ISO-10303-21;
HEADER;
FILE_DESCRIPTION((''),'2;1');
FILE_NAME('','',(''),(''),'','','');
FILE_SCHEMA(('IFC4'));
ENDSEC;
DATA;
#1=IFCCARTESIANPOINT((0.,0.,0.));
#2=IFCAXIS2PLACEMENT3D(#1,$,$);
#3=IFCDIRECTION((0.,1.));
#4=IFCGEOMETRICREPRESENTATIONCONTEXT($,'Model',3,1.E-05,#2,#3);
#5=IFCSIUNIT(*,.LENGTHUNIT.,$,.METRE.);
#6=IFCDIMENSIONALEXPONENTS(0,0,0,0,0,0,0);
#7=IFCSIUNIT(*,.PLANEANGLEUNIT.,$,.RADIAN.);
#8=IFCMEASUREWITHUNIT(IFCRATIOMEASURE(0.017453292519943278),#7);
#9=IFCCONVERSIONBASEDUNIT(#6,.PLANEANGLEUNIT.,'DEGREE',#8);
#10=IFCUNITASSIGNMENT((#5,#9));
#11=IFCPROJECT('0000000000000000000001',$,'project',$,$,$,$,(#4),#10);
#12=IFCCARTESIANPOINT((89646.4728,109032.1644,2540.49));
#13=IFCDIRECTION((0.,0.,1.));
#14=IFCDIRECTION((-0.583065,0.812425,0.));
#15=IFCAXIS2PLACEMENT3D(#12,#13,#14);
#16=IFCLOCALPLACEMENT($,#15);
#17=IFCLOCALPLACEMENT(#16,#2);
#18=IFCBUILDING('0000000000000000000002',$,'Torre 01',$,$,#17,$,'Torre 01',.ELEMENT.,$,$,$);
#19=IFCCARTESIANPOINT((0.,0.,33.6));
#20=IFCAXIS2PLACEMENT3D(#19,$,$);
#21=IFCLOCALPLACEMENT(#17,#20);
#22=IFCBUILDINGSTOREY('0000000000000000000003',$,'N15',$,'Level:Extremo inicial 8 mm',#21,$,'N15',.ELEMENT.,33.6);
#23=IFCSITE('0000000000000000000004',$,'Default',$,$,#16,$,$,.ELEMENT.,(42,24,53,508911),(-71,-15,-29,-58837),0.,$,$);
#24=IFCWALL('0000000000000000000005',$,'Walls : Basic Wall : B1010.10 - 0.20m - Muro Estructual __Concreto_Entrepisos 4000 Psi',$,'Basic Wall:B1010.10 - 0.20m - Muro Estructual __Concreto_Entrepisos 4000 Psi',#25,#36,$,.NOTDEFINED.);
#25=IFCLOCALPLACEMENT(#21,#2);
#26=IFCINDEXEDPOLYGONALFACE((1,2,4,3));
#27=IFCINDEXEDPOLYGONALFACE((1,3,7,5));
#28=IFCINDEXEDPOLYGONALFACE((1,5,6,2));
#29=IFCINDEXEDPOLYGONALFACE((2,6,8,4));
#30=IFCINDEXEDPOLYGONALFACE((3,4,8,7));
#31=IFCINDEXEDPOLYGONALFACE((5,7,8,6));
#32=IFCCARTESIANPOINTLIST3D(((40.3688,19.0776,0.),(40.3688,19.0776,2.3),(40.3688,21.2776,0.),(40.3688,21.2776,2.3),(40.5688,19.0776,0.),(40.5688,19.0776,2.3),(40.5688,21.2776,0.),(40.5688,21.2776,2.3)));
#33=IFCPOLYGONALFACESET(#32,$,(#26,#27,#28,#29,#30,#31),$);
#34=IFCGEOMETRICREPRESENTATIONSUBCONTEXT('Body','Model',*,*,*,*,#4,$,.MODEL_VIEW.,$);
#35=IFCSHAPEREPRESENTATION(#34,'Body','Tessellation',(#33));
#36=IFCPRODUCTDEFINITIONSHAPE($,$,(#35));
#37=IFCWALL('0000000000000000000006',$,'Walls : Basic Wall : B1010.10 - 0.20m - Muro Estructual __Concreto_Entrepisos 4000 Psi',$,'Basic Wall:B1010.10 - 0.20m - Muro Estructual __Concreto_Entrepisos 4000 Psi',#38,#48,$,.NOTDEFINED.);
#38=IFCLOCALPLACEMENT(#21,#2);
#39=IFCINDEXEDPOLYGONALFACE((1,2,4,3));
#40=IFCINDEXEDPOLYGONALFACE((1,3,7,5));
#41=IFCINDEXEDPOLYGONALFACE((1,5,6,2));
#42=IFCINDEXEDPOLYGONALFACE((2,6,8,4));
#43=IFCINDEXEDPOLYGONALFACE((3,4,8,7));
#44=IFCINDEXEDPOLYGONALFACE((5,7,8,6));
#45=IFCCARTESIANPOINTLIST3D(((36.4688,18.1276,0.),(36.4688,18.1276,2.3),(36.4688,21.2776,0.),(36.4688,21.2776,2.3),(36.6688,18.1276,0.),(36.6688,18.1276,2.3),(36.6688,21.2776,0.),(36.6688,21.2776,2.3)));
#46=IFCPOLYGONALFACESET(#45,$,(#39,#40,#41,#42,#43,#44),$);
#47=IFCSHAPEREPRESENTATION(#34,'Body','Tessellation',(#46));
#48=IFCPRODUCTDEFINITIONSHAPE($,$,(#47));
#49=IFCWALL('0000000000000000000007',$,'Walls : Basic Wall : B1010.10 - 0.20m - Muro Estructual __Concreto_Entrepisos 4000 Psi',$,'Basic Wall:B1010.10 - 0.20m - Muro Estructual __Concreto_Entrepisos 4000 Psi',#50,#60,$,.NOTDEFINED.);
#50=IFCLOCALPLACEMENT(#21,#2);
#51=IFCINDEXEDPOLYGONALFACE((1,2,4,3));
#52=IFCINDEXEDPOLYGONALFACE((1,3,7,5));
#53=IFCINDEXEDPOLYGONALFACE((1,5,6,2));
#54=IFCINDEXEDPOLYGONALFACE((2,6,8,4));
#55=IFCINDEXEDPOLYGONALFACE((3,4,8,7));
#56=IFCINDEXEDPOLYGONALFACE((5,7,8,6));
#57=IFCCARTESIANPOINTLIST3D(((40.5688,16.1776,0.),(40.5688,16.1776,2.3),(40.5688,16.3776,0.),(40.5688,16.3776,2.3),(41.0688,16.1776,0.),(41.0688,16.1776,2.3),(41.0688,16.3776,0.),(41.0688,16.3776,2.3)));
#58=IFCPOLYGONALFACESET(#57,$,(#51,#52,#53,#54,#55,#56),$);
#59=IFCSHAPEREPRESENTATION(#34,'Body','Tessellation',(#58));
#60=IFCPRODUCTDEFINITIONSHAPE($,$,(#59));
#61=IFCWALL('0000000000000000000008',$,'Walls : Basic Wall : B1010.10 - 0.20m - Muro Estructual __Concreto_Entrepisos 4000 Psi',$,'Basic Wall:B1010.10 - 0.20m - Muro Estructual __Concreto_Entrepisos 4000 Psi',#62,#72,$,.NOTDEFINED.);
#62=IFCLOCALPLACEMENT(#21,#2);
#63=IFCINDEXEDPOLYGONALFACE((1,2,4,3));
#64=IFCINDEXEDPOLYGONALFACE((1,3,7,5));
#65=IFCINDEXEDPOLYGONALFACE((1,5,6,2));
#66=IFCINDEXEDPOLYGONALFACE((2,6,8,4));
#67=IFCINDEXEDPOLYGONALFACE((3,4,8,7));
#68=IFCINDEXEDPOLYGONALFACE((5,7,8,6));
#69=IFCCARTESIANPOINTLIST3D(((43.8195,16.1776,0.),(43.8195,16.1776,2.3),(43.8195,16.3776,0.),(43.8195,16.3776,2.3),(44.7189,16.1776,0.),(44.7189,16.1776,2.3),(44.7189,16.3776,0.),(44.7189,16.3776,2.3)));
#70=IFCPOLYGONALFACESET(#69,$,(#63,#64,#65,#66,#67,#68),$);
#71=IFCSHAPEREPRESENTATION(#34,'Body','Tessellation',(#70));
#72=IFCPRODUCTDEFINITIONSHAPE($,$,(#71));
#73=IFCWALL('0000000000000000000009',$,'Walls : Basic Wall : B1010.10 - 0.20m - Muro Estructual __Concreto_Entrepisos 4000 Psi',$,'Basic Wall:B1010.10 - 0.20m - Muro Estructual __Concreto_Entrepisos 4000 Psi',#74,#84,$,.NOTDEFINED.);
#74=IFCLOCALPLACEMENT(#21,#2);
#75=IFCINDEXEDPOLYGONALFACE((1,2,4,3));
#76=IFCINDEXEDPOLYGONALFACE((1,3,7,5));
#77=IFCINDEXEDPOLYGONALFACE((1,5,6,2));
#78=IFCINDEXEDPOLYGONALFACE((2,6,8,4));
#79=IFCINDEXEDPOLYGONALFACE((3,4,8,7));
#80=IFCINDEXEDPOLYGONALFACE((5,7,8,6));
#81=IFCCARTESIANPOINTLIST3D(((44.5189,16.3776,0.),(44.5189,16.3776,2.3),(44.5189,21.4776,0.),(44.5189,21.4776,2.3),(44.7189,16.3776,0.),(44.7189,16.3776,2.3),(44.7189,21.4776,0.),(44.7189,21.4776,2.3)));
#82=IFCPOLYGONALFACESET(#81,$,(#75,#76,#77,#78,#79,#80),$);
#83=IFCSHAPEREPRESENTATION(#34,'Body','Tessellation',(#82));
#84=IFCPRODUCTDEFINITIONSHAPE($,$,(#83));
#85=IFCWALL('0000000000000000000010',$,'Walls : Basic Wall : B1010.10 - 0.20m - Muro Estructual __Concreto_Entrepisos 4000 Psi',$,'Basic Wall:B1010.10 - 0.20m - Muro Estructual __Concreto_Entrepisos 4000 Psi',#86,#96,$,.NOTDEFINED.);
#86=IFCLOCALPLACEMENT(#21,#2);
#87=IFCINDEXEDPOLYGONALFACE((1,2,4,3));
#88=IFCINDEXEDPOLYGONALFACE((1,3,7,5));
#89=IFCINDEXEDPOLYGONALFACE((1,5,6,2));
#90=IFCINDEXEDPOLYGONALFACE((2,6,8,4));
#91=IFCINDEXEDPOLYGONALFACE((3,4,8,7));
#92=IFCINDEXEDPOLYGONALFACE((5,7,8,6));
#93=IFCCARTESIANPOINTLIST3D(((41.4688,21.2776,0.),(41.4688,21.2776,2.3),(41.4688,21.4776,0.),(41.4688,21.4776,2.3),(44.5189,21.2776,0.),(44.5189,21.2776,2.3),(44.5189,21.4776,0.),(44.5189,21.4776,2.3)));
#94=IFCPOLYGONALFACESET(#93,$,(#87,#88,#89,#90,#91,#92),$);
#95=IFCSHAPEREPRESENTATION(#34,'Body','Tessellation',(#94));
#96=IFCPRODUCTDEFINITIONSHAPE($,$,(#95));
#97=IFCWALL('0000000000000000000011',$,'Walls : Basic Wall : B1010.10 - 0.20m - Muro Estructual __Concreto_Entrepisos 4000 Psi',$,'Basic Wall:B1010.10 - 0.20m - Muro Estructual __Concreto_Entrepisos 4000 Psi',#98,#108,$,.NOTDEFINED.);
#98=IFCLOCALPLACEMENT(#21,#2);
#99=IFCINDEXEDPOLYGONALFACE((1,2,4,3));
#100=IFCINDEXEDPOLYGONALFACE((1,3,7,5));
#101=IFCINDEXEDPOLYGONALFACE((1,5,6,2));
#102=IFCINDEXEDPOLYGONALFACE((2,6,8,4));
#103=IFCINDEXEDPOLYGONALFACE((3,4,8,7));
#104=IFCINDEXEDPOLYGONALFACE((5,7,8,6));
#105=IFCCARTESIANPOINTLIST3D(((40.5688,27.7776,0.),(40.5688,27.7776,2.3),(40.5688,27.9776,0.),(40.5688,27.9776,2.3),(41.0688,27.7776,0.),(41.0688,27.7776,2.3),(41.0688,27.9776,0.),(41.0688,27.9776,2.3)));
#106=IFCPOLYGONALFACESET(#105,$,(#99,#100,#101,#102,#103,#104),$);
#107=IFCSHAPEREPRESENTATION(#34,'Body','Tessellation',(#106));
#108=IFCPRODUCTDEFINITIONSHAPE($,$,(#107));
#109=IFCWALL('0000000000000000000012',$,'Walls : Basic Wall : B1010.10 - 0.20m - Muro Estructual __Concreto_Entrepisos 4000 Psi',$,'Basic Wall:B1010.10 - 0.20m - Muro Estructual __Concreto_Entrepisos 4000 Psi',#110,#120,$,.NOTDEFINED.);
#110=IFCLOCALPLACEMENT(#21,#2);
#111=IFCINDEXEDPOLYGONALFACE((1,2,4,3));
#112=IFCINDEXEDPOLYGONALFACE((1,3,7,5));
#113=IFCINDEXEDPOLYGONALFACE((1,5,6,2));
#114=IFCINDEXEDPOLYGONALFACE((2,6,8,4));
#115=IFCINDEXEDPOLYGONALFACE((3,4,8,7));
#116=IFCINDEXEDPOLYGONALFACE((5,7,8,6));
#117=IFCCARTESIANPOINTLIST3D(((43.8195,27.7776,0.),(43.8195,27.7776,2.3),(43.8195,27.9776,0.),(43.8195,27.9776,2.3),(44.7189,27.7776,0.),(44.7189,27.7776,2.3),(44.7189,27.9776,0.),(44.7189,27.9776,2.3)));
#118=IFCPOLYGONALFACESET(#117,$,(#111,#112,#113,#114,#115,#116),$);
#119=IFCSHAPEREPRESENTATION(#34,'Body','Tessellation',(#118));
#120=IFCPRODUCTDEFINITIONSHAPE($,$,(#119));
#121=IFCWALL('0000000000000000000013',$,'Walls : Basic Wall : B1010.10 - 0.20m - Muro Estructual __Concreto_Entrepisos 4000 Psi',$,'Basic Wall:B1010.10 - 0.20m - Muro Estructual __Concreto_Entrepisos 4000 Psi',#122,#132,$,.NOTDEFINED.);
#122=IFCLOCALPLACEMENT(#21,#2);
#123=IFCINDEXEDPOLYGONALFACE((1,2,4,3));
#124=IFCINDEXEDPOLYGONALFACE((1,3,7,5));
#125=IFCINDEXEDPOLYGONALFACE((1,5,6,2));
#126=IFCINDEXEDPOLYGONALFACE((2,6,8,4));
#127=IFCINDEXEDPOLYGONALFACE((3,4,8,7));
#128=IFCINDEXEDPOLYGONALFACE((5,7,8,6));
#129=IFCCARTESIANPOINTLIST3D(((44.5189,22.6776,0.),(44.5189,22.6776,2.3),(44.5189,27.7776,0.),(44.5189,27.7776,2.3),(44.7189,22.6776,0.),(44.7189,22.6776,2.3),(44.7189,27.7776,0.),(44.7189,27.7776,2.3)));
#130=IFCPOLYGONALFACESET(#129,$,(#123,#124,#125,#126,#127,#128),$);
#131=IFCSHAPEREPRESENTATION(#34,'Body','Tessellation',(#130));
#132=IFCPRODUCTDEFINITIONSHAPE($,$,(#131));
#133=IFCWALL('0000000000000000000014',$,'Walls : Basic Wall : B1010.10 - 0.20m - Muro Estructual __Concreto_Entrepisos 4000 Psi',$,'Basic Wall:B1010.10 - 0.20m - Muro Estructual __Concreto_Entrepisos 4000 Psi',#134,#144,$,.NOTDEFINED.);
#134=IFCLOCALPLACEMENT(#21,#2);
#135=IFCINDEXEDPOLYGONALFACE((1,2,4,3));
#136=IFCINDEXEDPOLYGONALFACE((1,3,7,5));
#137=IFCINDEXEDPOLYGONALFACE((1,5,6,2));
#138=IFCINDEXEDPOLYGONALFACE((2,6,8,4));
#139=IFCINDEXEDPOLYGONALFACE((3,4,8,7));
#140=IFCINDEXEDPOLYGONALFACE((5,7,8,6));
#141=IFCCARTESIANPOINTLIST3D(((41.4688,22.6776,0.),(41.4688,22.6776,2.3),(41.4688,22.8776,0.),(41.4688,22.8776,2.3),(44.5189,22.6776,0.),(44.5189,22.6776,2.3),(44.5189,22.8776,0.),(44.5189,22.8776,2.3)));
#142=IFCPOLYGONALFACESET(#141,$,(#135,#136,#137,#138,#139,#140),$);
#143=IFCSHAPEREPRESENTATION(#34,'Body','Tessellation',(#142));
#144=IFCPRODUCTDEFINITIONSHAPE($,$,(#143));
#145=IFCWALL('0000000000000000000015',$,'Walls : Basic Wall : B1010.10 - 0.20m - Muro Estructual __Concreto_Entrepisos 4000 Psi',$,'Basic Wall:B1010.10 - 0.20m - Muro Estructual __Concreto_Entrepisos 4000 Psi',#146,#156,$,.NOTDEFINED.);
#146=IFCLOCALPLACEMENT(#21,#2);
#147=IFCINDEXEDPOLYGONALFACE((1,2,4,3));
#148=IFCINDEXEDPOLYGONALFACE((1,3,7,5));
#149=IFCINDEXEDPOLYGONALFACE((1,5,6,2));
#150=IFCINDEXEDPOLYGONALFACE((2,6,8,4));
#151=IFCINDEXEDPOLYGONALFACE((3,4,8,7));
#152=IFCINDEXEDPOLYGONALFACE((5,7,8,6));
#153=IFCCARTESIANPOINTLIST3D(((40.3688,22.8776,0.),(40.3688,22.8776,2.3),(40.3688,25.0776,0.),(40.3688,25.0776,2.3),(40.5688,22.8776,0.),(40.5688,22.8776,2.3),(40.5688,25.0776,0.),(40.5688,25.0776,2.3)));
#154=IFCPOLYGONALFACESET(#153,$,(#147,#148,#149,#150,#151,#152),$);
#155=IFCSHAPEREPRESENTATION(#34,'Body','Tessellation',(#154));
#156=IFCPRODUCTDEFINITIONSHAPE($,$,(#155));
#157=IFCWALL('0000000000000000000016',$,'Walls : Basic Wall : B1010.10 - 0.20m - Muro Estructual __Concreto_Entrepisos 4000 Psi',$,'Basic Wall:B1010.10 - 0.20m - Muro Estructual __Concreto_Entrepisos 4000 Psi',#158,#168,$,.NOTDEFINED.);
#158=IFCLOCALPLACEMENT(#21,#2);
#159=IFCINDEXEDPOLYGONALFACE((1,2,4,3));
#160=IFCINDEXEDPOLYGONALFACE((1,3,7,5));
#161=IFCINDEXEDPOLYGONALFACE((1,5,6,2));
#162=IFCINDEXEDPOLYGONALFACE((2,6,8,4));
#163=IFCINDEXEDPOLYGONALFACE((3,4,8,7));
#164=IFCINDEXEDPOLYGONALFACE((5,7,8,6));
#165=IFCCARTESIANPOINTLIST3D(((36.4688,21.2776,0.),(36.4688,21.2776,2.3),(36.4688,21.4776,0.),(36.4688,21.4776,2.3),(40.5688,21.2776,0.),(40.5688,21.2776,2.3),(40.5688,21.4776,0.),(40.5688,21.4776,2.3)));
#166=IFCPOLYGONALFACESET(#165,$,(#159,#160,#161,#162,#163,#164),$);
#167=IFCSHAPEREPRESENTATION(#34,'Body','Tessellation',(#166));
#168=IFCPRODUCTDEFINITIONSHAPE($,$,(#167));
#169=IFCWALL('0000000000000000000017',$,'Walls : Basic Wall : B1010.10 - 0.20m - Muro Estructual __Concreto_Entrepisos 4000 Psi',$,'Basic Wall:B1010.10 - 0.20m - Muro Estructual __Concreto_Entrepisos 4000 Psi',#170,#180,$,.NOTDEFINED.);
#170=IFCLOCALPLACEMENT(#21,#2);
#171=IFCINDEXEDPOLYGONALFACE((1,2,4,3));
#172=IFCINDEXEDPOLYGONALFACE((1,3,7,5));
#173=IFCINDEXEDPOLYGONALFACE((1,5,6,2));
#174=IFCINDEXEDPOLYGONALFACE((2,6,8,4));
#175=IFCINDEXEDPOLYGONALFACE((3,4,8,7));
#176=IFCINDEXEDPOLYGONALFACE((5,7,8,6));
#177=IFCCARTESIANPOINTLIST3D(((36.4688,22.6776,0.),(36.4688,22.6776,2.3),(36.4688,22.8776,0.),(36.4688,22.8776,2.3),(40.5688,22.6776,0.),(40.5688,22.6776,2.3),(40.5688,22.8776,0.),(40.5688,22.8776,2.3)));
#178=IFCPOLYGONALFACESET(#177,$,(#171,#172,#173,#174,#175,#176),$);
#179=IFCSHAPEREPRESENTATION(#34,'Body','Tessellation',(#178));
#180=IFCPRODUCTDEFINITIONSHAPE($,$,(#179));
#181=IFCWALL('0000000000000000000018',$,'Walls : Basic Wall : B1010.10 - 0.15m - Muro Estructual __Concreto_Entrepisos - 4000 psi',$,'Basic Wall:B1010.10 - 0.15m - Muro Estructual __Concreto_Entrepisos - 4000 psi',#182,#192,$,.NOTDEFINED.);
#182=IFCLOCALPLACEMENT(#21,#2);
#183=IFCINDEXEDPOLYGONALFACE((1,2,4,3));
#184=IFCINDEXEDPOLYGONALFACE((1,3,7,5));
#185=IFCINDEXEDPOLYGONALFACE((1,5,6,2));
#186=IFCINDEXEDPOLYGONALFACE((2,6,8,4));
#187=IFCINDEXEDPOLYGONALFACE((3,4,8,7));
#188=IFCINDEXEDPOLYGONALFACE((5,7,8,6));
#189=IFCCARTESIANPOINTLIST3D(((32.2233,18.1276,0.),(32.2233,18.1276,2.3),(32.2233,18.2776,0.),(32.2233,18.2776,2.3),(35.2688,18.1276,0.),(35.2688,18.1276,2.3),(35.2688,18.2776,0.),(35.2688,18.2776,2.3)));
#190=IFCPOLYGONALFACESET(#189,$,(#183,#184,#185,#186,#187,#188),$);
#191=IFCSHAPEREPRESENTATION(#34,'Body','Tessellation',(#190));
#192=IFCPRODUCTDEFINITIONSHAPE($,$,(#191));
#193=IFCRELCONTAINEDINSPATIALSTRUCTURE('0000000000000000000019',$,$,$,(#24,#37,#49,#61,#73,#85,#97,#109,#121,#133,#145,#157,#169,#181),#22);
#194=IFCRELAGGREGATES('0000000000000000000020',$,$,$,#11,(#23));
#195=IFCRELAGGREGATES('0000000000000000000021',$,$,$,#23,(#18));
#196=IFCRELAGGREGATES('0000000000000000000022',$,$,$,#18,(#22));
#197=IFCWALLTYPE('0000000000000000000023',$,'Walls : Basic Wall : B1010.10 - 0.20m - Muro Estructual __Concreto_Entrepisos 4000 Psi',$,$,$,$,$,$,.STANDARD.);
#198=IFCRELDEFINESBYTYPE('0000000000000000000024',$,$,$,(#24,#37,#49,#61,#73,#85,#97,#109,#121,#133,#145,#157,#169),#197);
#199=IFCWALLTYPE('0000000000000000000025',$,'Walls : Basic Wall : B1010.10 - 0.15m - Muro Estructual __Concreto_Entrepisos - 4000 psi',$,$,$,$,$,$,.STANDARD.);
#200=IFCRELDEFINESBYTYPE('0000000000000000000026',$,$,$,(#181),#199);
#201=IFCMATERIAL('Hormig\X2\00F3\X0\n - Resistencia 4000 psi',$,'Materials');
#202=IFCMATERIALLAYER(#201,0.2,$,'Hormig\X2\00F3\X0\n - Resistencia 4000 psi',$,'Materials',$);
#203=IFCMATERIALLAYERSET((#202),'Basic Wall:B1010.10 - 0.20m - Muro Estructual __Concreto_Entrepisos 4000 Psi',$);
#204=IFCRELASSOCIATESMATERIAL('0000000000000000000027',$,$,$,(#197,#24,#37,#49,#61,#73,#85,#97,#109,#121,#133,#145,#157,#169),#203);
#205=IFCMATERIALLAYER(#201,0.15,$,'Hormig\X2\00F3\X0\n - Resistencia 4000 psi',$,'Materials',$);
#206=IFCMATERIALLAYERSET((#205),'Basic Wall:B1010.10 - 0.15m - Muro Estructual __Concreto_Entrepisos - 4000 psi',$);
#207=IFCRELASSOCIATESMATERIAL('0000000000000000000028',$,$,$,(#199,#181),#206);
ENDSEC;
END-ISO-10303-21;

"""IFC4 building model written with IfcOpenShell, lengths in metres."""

from ifc_helpers import new_model, entity, si_unit, converted_unit, direction, frame, frame_2d, origin, place, context, subcontext, project, spatial, rectangle, extrude, material, layer, layer_set, layer_usage, type_object, element, save


model = new_model("IFC4")

# Units and contexts
model_context = context("Model", 3, precision=1e-05, world=origin(), true_north=direction((0.0, 1.0)))
body_context = subcontext(model_context, "Body", "Model", "MODEL_VIEW")
ifc_project = project(units=[si_unit("LENGTHUNIT", "METRE"), converted_unit("PLANEANGLEUNIT", "DEGREE", entity("IfcRatioMeasure", 0.017453292519943278), si_unit("PLANEANGLEUNIT", "RADIAN"), dimensions=[0, 0, 0, 0, 0, 0, 0])], contexts=[model_context])

# Site, building, storey
site_placement = place(None, frame((89646.4728, 109032.1644, 2540.49), z_axis=(0.0, 0.0, 1.0), x_axis=(-0.583065, 0.812425, 0.0)))
site = spatial("IfcSite", under=ifc_project, at=site_placement, Name="Default", CompositionType="ELEMENT", RefLatitude=(42, 24, 53, 508911), RefLongitude=(-71, -15, -29, -58837), RefElevation=0.0)
building_placement = place(site_placement, origin())
building = spatial("IfcBuilding", under=site, at=building_placement, Name="Torre 01", LongName="Torre 01", CompositionType="ELEMENT")
storey_placement = place(building_placement, frame((0.0, 0.0, 33.6)))
storey = spatial("IfcBuildingStorey", under=building, at=storey_placement, Name="N15", ObjectType="Level:Extremo inicial 8 mm", LongName="N15", CompositionType="ELEMENT", Elevation=33.6)

# Walls
ifc_material = material(Name="Hormigón - Resistencia 4000 psi", Category="Materials")
ifc_layer_1 = layer(ifc_material, 0.2, Name="Hormigón - Resistencia 4000 psi", Category="Materials")
ifc_layer_set_1 = layer_set([ifc_layer_1], Name="Basic Wall:B1010.10 - 0.20m - Muro Estructual __Concreto_Entrepisos 4000 Psi")
ifc_layer_usage_1 = layer_usage(ifc_layer_set_1, "AXIS2", "NEGATIVE", 0.1)
wall_type_1 = type_object("IfcWallType", Name="Walls : Basic Wall : B1010.10 - 0.20m - Muro Estructual __Concreto_Entrepisos 4000 Psi", PredefinedType="STANDARD", material=ifc_layer_set_1)
wall_1_placement = place(storey_placement, frame((40.4688, 21.2776, 0.0), z_axis=(0.0, 0.0, 1.0), x_axis=(0.0, -1.0, 0.0)))
element("IfcWall", 1, at=wall_1_placement, inside=storey, type_object=wall_type_1, material=ifc_layer_usage_1, Name="Walls : Basic Wall : B1010.10 - 0.20m - Muro Estructual __Concreto_Entrepisos 4000 Psi", ObjectType="Basic Wall:B1010.10 - 0.20m - Muro Estructual __Concreto_Entrepisos 4000 Psi", PredefinedType="NOTDEFINED", context=body_context, shape_type="SweptSolid", body=[
    extrude(rectangle(XDim=2.2, YDim=0.2, at=frame_2d((1.1, 0.0), x_axis=(-1.0, 0.0))), origin(), (0.0, 0.0, 1.0), 2.3),
])
ifc_layer_usage_2 = layer_usage(ifc_layer_set_1, "AXIS2", "NEGATIVE", 0.1)
wall_2_placement = place(storey_placement, frame((36.5688, 18.1276, 0.0), z_axis=(0.0, 0.0, 1.0), x_axis=(0.0, 1.0, 0.0)))
element("IfcWall", 2, at=wall_2_placement, inside=storey, type_object=wall_type_1, material=ifc_layer_usage_2, Name="Walls : Basic Wall : B1010.10 - 0.20m - Muro Estructual __Concreto_Entrepisos 4000 Psi", ObjectType="Basic Wall:B1010.10 - 0.20m - Muro Estructual __Concreto_Entrepisos 4000 Psi", PredefinedType="NOTDEFINED", context=body_context, shape_type="SweptSolid", body=[
    extrude(rectangle(XDim=3.15, YDim=0.2, at=frame_2d((1.575, 0.0), x_axis=(-1.0, 0.0))), origin(), (0.0, 0.0, 1.0), 2.3),
])
ifc_layer_usage_3 = layer_usage(ifc_layer_set_1, "AXIS2", "NEGATIVE", 0.1)
wall_3_placement = place(storey_placement, frame((41.0688, 16.2776, 0.0), z_axis=(0.0, 0.0, 1.0), x_axis=(-1.0, 0.0, 0.0)))
element("IfcWall", 3, at=wall_3_placement, inside=storey, type_object=wall_type_1, material=ifc_layer_usage_3, Name="Walls : Basic Wall : B1010.10 - 0.20m - Muro Estructual __Concreto_Entrepisos 4000 Psi", ObjectType="Basic Wall:B1010.10 - 0.20m - Muro Estructual __Concreto_Entrepisos 4000 Psi", PredefinedType="NOTDEFINED", context=body_context, shape_type="SweptSolid", body=[
    extrude(rectangle(XDim=0.5, YDim=0.2, at=frame_2d((0.25, 0.0), x_axis=(-1.0, 0.0))), origin(), (0.0, 0.0, 1.0), 2.3),
])
ifc_layer_usage_4 = layer_usage(ifc_layer_set_1, "AXIS2", "NEGATIVE", 0.1)
wall_4_placement = place(storey_placement, frame((43.8195, 16.2776, 0.0)))
element("IfcWall", 4, at=wall_4_placement, inside=storey, type_object=wall_type_1, material=ifc_layer_usage_4, Name="Walls : Basic Wall : B1010.10 - 0.20m - Muro Estructual __Concreto_Entrepisos 4000 Psi", ObjectType="Basic Wall:B1010.10 - 0.20m - Muro Estructual __Concreto_Entrepisos 4000 Psi", PredefinedType="NOTDEFINED", context=body_context, shape_type="SweptSolid", body=[
    extrude(rectangle(XDim=0.8993, YDim=0.2, at=frame_2d((0.4497, 0.0), x_axis=(-1.0, 0.0))), origin(), (0.0, 0.0, 1.0), 2.3),
])
ifc_layer_usage_5 = layer_usage(ifc_layer_set_1, "AXIS2", "NEGATIVE", 0.1)
wall_5_placement = place(storey_placement, frame((44.6189, 21.4776, 0.0), z_axis=(0.0, 0.0, 1.0), x_axis=(0.0, -1.0, 0.0)))
element("IfcWall", 5, at=wall_5_placement, inside=storey, type_object=wall_type_1, material=ifc_layer_usage_5, Name="Walls : Basic Wall : B1010.10 - 0.20m - Muro Estructual __Concreto_Entrepisos 4000 Psi", ObjectType="Basic Wall:B1010.10 - 0.20m - Muro Estructual __Concreto_Entrepisos 4000 Psi", PredefinedType="NOTDEFINED", context=body_context, shape_type="SweptSolid", body=[
    extrude(rectangle(XDim=5.1, YDim=0.2, at=frame_2d((2.55, 0.0), x_axis=(-1.0, 0.0))), origin(), (0.0, 0.0, 1.0), 2.3),
])
ifc_layer_usage_6 = layer_usage(ifc_layer_set_1, "AXIS2", "NEGATIVE", 0.1)
wall_6_placement = place(storey_placement, frame((41.4688, 21.3776, 0.0)))
element("IfcWall", 6, at=wall_6_placement, inside=storey, type_object=wall_type_1, material=ifc_layer_usage_6, Name="Walls : Basic Wall : B1010.10 - 0.20m - Muro Estructual __Concreto_Entrepisos 4000 Psi", ObjectType="Basic Wall:B1010.10 - 0.20m - Muro Estructual __Concreto_Entrepisos 4000 Psi", PredefinedType="NOTDEFINED", context=body_context, shape_type="SweptSolid", body=[
    extrude(rectangle(XDim=3.05, YDim=0.2, at=frame_2d((1.525, 0.0), x_axis=(-1.0, 0.0))), origin(), (0.0, 0.0, 1.0), 2.3),
])
ifc_layer_usage_7 = layer_usage(ifc_layer_set_1, "AXIS2", "POSITIVE", -0.1)
wall_7_placement = place(storey_placement, frame((41.0688, 27.8776, 0.0), z_axis=(0.0, 0.0, 1.0), x_axis=(-1.0, 0.0, 0.0)))
element("IfcWall", 7, at=wall_7_placement, inside=storey, type_object=wall_type_1, material=ifc_layer_usage_7, Name="Walls : Basic Wall : B1010.10 - 0.20m - Muro Estructual __Concreto_Entrepisos 4000 Psi", ObjectType="Basic Wall:B1010.10 - 0.20m - Muro Estructual __Concreto_Entrepisos 4000 Psi", PredefinedType="NOTDEFINED", context=body_context, shape_type="SweptSolid", body=[
    extrude(rectangle(XDim=0.5, YDim=0.2, at=frame_2d((0.25, 0.0), x_axis=(-1.0, 0.0))), origin(), (0.0, 0.0, 1.0), 2.3),
])
ifc_layer_usage_8 = layer_usage(ifc_layer_set_1, "AXIS2", "POSITIVE", -0.1)
wall_8_placement = place(storey_placement, frame((43.8195, 27.8776, 0.0)))
element("IfcWall", 8, at=wall_8_placement, inside=storey, type_object=wall_type_1, material=ifc_layer_usage_8, Name="Walls : Basic Wall : B1010.10 - 0.20m - Muro Estructual __Concreto_Entrepisos 4000 Psi", ObjectType="Basic Wall:B1010.10 - 0.20m - Muro Estructual __Concreto_Entrepisos 4000 Psi", PredefinedType="NOTDEFINED", context=body_context, shape_type="SweptSolid", body=[
    extrude(rectangle(XDim=0.8993, YDim=0.2, at=frame_2d((0.4497, 0.0), x_axis=(-1.0, 0.0))), origin(), (0.0, 0.0, 1.0), 2.3),
])
ifc_layer_usage_9 = layer_usage(ifc_layer_set_1, "AXIS2", "POSITIVE", -0.1)
wall_9_placement = place(storey_placement, frame((44.6189, 22.6776, 0.0), z_axis=(0.0, 0.0, 1.0), x_axis=(0.0, 1.0, 0.0)))
element("IfcWall", 9, at=wall_9_placement, inside=storey, type_object=wall_type_1, material=ifc_layer_usage_9, Name="Walls : Basic Wall : B1010.10 - 0.20m - Muro Estructual __Concreto_Entrepisos 4000 Psi", ObjectType="Basic Wall:B1010.10 - 0.20m - Muro Estructual __Concreto_Entrepisos 4000 Psi", PredefinedType="NOTDEFINED", context=body_context, shape_type="SweptSolid", body=[
    extrude(rectangle(XDim=5.1, YDim=0.2, at=frame_2d((2.55, 0.0), x_axis=(-1.0, 0.0))), origin(), (0.0, 0.0, 1.0), 2.3),
])
ifc_layer_usage_10 = layer_usage(ifc_layer_set_1, "AXIS2", "POSITIVE", -0.1)
wall_10_placement = place(storey_placement, frame((41.4688, 22.7776, 0.0)))
element("IfcWall", 10, at=wall_10_placement, inside=storey, type_object=wall_type_1, material=ifc_layer_usage_10, Name="Walls : Basic Wall : B1010.10 - 0.20m - Muro Estructual __Concreto_Entrepisos 4000 Psi", ObjectType="Basic Wall:B1010.10 - 0.20m - Muro Estructual __Concreto_Entrepisos 4000 Psi", PredefinedType="NOTDEFINED", context=body_context, shape_type="SweptSolid", body=[
    extrude(rectangle(XDim=3.05, YDim=0.2, at=frame_2d((1.525, 0.0), x_axis=(-1.0, 0.0))), origin(), (0.0, 0.0, 1.0), 2.3),
])
ifc_layer_usage_11 = layer_usage(ifc_layer_set_1, "AXIS2", "POSITIVE", -0.1)
wall_11_placement = place(storey_placement, frame((40.4688, 22.8776, 0.0), z_axis=(0.0, 0.0, 1.0), x_axis=(0.0, 1.0, 0.0)))
element("IfcWall", 11, at=wall_11_placement, inside=storey, type_object=wall_type_1, material=ifc_layer_usage_11, Name="Walls : Basic Wall : B1010.10 - 0.20m - Muro Estructual __Concreto_Entrepisos 4000 Psi", ObjectType="Basic Wall:B1010.10 - 0.20m - Muro Estructual __Concreto_Entrepisos 4000 Psi", PredefinedType="NOTDEFINED", context=body_context, shape_type="SweptSolid", body=[
    extrude(rectangle(XDim=2.2, YDim=0.2, at=frame_2d((1.1, 0.0), x_axis=(-1.0, 0.0))), origin(), (0.0, 0.0, 1.0), 2.3),
])
ifc_layer_usage_12 = layer_usage(ifc_layer_set_1, "AXIS2", "NEGATIVE", 0.1)
wall_12_placement = place(storey_placement, frame((36.4688, 21.3776, 0.0)))
element("IfcWall", 12, at=wall_12_placement, inside=storey, type_object=wall_type_1, material=ifc_layer_usage_12, Name="Walls : Basic Wall : B1010.10 - 0.20m - Muro Estructual __Concreto_Entrepisos 4000 Psi", ObjectType="Basic Wall:B1010.10 - 0.20m - Muro Estructual __Concreto_Entrepisos 4000 Psi", PredefinedType="NOTDEFINED", context=body_context, shape_type="SweptSolid", body=[
    extrude(rectangle(XDim=4.1, YDim=0.2, at=frame_2d((2.05, 0.0), x_axis=(-1.0, 0.0))), origin(), (0.0, 0.0, 1.0), 2.3),
])
ifc_layer_usage_13 = layer_usage(ifc_layer_set_1, "AXIS2", "POSITIVE", -0.1)
wall_13_placement = place(storey_placement, frame((36.4688, 22.7776, 0.0)))
element("IfcWall", 13, at=wall_13_placement, inside=storey, type_object=wall_type_1, material=ifc_layer_usage_13, Name="Walls : Basic Wall : B1010.10 - 0.20m - Muro Estructual __Concreto_Entrepisos 4000 Psi", ObjectType="Basic Wall:B1010.10 - 0.20m - Muro Estructual __Concreto_Entrepisos 4000 Psi", PredefinedType="NOTDEFINED", context=body_context, shape_type="SweptSolid", body=[
    extrude(rectangle(XDim=4.1, YDim=0.2, at=frame_2d((2.05, 0.0), x_axis=(-1.0, 0.0))), origin(), (0.0, 0.0, 1.0), 2.3),
])
ifc_layer_2 = layer(ifc_material, 0.15, Name="Hormigón - Resistencia 4000 psi", Category="Materials")
ifc_layer_set_2 = layer_set([ifc_layer_2], Name="Basic Wall:B1010.10 - 0.15m - Muro Estructual __Concreto_Entrepisos - 4000 psi")
ifc_layer_usage_14 = layer_usage(ifc_layer_set_2, "AXIS2", "NEGATIVE", 0.075)
wall_type_2 = type_object("IfcWallType", Name="Walls : Basic Wall : B1010.10 - 0.15m - Muro Estructual __Concreto_Entrepisos - 4000 psi", PredefinedType="STANDARD", material=ifc_layer_set_2)
wall_14_placement = place(storey_placement, frame((32.2233, 18.2026, 0.0)))
element("IfcWall", 14, at=wall_14_placement, inside=storey, type_object=wall_type_2, material=ifc_layer_usage_14, Name="Walls : Basic Wall : B1010.10 - 0.15m - Muro Estructual __Concreto_Entrepisos - 4000 psi", ObjectType="Basic Wall:B1010.10 - 0.15m - Muro Estructual __Concreto_Entrepisos - 4000 psi", PredefinedType="NOTDEFINED", context=body_context, shape_type="SweptSolid", body=[
    extrude(rectangle(XDim=3.0455, YDim=0.15, at=frame_2d((1.5228, 0.0), x_axis=(-1.0, 0.0))), origin(), (0.0, 0.0, 1.0), 2.3),
])

save(model, "model.ifc")
